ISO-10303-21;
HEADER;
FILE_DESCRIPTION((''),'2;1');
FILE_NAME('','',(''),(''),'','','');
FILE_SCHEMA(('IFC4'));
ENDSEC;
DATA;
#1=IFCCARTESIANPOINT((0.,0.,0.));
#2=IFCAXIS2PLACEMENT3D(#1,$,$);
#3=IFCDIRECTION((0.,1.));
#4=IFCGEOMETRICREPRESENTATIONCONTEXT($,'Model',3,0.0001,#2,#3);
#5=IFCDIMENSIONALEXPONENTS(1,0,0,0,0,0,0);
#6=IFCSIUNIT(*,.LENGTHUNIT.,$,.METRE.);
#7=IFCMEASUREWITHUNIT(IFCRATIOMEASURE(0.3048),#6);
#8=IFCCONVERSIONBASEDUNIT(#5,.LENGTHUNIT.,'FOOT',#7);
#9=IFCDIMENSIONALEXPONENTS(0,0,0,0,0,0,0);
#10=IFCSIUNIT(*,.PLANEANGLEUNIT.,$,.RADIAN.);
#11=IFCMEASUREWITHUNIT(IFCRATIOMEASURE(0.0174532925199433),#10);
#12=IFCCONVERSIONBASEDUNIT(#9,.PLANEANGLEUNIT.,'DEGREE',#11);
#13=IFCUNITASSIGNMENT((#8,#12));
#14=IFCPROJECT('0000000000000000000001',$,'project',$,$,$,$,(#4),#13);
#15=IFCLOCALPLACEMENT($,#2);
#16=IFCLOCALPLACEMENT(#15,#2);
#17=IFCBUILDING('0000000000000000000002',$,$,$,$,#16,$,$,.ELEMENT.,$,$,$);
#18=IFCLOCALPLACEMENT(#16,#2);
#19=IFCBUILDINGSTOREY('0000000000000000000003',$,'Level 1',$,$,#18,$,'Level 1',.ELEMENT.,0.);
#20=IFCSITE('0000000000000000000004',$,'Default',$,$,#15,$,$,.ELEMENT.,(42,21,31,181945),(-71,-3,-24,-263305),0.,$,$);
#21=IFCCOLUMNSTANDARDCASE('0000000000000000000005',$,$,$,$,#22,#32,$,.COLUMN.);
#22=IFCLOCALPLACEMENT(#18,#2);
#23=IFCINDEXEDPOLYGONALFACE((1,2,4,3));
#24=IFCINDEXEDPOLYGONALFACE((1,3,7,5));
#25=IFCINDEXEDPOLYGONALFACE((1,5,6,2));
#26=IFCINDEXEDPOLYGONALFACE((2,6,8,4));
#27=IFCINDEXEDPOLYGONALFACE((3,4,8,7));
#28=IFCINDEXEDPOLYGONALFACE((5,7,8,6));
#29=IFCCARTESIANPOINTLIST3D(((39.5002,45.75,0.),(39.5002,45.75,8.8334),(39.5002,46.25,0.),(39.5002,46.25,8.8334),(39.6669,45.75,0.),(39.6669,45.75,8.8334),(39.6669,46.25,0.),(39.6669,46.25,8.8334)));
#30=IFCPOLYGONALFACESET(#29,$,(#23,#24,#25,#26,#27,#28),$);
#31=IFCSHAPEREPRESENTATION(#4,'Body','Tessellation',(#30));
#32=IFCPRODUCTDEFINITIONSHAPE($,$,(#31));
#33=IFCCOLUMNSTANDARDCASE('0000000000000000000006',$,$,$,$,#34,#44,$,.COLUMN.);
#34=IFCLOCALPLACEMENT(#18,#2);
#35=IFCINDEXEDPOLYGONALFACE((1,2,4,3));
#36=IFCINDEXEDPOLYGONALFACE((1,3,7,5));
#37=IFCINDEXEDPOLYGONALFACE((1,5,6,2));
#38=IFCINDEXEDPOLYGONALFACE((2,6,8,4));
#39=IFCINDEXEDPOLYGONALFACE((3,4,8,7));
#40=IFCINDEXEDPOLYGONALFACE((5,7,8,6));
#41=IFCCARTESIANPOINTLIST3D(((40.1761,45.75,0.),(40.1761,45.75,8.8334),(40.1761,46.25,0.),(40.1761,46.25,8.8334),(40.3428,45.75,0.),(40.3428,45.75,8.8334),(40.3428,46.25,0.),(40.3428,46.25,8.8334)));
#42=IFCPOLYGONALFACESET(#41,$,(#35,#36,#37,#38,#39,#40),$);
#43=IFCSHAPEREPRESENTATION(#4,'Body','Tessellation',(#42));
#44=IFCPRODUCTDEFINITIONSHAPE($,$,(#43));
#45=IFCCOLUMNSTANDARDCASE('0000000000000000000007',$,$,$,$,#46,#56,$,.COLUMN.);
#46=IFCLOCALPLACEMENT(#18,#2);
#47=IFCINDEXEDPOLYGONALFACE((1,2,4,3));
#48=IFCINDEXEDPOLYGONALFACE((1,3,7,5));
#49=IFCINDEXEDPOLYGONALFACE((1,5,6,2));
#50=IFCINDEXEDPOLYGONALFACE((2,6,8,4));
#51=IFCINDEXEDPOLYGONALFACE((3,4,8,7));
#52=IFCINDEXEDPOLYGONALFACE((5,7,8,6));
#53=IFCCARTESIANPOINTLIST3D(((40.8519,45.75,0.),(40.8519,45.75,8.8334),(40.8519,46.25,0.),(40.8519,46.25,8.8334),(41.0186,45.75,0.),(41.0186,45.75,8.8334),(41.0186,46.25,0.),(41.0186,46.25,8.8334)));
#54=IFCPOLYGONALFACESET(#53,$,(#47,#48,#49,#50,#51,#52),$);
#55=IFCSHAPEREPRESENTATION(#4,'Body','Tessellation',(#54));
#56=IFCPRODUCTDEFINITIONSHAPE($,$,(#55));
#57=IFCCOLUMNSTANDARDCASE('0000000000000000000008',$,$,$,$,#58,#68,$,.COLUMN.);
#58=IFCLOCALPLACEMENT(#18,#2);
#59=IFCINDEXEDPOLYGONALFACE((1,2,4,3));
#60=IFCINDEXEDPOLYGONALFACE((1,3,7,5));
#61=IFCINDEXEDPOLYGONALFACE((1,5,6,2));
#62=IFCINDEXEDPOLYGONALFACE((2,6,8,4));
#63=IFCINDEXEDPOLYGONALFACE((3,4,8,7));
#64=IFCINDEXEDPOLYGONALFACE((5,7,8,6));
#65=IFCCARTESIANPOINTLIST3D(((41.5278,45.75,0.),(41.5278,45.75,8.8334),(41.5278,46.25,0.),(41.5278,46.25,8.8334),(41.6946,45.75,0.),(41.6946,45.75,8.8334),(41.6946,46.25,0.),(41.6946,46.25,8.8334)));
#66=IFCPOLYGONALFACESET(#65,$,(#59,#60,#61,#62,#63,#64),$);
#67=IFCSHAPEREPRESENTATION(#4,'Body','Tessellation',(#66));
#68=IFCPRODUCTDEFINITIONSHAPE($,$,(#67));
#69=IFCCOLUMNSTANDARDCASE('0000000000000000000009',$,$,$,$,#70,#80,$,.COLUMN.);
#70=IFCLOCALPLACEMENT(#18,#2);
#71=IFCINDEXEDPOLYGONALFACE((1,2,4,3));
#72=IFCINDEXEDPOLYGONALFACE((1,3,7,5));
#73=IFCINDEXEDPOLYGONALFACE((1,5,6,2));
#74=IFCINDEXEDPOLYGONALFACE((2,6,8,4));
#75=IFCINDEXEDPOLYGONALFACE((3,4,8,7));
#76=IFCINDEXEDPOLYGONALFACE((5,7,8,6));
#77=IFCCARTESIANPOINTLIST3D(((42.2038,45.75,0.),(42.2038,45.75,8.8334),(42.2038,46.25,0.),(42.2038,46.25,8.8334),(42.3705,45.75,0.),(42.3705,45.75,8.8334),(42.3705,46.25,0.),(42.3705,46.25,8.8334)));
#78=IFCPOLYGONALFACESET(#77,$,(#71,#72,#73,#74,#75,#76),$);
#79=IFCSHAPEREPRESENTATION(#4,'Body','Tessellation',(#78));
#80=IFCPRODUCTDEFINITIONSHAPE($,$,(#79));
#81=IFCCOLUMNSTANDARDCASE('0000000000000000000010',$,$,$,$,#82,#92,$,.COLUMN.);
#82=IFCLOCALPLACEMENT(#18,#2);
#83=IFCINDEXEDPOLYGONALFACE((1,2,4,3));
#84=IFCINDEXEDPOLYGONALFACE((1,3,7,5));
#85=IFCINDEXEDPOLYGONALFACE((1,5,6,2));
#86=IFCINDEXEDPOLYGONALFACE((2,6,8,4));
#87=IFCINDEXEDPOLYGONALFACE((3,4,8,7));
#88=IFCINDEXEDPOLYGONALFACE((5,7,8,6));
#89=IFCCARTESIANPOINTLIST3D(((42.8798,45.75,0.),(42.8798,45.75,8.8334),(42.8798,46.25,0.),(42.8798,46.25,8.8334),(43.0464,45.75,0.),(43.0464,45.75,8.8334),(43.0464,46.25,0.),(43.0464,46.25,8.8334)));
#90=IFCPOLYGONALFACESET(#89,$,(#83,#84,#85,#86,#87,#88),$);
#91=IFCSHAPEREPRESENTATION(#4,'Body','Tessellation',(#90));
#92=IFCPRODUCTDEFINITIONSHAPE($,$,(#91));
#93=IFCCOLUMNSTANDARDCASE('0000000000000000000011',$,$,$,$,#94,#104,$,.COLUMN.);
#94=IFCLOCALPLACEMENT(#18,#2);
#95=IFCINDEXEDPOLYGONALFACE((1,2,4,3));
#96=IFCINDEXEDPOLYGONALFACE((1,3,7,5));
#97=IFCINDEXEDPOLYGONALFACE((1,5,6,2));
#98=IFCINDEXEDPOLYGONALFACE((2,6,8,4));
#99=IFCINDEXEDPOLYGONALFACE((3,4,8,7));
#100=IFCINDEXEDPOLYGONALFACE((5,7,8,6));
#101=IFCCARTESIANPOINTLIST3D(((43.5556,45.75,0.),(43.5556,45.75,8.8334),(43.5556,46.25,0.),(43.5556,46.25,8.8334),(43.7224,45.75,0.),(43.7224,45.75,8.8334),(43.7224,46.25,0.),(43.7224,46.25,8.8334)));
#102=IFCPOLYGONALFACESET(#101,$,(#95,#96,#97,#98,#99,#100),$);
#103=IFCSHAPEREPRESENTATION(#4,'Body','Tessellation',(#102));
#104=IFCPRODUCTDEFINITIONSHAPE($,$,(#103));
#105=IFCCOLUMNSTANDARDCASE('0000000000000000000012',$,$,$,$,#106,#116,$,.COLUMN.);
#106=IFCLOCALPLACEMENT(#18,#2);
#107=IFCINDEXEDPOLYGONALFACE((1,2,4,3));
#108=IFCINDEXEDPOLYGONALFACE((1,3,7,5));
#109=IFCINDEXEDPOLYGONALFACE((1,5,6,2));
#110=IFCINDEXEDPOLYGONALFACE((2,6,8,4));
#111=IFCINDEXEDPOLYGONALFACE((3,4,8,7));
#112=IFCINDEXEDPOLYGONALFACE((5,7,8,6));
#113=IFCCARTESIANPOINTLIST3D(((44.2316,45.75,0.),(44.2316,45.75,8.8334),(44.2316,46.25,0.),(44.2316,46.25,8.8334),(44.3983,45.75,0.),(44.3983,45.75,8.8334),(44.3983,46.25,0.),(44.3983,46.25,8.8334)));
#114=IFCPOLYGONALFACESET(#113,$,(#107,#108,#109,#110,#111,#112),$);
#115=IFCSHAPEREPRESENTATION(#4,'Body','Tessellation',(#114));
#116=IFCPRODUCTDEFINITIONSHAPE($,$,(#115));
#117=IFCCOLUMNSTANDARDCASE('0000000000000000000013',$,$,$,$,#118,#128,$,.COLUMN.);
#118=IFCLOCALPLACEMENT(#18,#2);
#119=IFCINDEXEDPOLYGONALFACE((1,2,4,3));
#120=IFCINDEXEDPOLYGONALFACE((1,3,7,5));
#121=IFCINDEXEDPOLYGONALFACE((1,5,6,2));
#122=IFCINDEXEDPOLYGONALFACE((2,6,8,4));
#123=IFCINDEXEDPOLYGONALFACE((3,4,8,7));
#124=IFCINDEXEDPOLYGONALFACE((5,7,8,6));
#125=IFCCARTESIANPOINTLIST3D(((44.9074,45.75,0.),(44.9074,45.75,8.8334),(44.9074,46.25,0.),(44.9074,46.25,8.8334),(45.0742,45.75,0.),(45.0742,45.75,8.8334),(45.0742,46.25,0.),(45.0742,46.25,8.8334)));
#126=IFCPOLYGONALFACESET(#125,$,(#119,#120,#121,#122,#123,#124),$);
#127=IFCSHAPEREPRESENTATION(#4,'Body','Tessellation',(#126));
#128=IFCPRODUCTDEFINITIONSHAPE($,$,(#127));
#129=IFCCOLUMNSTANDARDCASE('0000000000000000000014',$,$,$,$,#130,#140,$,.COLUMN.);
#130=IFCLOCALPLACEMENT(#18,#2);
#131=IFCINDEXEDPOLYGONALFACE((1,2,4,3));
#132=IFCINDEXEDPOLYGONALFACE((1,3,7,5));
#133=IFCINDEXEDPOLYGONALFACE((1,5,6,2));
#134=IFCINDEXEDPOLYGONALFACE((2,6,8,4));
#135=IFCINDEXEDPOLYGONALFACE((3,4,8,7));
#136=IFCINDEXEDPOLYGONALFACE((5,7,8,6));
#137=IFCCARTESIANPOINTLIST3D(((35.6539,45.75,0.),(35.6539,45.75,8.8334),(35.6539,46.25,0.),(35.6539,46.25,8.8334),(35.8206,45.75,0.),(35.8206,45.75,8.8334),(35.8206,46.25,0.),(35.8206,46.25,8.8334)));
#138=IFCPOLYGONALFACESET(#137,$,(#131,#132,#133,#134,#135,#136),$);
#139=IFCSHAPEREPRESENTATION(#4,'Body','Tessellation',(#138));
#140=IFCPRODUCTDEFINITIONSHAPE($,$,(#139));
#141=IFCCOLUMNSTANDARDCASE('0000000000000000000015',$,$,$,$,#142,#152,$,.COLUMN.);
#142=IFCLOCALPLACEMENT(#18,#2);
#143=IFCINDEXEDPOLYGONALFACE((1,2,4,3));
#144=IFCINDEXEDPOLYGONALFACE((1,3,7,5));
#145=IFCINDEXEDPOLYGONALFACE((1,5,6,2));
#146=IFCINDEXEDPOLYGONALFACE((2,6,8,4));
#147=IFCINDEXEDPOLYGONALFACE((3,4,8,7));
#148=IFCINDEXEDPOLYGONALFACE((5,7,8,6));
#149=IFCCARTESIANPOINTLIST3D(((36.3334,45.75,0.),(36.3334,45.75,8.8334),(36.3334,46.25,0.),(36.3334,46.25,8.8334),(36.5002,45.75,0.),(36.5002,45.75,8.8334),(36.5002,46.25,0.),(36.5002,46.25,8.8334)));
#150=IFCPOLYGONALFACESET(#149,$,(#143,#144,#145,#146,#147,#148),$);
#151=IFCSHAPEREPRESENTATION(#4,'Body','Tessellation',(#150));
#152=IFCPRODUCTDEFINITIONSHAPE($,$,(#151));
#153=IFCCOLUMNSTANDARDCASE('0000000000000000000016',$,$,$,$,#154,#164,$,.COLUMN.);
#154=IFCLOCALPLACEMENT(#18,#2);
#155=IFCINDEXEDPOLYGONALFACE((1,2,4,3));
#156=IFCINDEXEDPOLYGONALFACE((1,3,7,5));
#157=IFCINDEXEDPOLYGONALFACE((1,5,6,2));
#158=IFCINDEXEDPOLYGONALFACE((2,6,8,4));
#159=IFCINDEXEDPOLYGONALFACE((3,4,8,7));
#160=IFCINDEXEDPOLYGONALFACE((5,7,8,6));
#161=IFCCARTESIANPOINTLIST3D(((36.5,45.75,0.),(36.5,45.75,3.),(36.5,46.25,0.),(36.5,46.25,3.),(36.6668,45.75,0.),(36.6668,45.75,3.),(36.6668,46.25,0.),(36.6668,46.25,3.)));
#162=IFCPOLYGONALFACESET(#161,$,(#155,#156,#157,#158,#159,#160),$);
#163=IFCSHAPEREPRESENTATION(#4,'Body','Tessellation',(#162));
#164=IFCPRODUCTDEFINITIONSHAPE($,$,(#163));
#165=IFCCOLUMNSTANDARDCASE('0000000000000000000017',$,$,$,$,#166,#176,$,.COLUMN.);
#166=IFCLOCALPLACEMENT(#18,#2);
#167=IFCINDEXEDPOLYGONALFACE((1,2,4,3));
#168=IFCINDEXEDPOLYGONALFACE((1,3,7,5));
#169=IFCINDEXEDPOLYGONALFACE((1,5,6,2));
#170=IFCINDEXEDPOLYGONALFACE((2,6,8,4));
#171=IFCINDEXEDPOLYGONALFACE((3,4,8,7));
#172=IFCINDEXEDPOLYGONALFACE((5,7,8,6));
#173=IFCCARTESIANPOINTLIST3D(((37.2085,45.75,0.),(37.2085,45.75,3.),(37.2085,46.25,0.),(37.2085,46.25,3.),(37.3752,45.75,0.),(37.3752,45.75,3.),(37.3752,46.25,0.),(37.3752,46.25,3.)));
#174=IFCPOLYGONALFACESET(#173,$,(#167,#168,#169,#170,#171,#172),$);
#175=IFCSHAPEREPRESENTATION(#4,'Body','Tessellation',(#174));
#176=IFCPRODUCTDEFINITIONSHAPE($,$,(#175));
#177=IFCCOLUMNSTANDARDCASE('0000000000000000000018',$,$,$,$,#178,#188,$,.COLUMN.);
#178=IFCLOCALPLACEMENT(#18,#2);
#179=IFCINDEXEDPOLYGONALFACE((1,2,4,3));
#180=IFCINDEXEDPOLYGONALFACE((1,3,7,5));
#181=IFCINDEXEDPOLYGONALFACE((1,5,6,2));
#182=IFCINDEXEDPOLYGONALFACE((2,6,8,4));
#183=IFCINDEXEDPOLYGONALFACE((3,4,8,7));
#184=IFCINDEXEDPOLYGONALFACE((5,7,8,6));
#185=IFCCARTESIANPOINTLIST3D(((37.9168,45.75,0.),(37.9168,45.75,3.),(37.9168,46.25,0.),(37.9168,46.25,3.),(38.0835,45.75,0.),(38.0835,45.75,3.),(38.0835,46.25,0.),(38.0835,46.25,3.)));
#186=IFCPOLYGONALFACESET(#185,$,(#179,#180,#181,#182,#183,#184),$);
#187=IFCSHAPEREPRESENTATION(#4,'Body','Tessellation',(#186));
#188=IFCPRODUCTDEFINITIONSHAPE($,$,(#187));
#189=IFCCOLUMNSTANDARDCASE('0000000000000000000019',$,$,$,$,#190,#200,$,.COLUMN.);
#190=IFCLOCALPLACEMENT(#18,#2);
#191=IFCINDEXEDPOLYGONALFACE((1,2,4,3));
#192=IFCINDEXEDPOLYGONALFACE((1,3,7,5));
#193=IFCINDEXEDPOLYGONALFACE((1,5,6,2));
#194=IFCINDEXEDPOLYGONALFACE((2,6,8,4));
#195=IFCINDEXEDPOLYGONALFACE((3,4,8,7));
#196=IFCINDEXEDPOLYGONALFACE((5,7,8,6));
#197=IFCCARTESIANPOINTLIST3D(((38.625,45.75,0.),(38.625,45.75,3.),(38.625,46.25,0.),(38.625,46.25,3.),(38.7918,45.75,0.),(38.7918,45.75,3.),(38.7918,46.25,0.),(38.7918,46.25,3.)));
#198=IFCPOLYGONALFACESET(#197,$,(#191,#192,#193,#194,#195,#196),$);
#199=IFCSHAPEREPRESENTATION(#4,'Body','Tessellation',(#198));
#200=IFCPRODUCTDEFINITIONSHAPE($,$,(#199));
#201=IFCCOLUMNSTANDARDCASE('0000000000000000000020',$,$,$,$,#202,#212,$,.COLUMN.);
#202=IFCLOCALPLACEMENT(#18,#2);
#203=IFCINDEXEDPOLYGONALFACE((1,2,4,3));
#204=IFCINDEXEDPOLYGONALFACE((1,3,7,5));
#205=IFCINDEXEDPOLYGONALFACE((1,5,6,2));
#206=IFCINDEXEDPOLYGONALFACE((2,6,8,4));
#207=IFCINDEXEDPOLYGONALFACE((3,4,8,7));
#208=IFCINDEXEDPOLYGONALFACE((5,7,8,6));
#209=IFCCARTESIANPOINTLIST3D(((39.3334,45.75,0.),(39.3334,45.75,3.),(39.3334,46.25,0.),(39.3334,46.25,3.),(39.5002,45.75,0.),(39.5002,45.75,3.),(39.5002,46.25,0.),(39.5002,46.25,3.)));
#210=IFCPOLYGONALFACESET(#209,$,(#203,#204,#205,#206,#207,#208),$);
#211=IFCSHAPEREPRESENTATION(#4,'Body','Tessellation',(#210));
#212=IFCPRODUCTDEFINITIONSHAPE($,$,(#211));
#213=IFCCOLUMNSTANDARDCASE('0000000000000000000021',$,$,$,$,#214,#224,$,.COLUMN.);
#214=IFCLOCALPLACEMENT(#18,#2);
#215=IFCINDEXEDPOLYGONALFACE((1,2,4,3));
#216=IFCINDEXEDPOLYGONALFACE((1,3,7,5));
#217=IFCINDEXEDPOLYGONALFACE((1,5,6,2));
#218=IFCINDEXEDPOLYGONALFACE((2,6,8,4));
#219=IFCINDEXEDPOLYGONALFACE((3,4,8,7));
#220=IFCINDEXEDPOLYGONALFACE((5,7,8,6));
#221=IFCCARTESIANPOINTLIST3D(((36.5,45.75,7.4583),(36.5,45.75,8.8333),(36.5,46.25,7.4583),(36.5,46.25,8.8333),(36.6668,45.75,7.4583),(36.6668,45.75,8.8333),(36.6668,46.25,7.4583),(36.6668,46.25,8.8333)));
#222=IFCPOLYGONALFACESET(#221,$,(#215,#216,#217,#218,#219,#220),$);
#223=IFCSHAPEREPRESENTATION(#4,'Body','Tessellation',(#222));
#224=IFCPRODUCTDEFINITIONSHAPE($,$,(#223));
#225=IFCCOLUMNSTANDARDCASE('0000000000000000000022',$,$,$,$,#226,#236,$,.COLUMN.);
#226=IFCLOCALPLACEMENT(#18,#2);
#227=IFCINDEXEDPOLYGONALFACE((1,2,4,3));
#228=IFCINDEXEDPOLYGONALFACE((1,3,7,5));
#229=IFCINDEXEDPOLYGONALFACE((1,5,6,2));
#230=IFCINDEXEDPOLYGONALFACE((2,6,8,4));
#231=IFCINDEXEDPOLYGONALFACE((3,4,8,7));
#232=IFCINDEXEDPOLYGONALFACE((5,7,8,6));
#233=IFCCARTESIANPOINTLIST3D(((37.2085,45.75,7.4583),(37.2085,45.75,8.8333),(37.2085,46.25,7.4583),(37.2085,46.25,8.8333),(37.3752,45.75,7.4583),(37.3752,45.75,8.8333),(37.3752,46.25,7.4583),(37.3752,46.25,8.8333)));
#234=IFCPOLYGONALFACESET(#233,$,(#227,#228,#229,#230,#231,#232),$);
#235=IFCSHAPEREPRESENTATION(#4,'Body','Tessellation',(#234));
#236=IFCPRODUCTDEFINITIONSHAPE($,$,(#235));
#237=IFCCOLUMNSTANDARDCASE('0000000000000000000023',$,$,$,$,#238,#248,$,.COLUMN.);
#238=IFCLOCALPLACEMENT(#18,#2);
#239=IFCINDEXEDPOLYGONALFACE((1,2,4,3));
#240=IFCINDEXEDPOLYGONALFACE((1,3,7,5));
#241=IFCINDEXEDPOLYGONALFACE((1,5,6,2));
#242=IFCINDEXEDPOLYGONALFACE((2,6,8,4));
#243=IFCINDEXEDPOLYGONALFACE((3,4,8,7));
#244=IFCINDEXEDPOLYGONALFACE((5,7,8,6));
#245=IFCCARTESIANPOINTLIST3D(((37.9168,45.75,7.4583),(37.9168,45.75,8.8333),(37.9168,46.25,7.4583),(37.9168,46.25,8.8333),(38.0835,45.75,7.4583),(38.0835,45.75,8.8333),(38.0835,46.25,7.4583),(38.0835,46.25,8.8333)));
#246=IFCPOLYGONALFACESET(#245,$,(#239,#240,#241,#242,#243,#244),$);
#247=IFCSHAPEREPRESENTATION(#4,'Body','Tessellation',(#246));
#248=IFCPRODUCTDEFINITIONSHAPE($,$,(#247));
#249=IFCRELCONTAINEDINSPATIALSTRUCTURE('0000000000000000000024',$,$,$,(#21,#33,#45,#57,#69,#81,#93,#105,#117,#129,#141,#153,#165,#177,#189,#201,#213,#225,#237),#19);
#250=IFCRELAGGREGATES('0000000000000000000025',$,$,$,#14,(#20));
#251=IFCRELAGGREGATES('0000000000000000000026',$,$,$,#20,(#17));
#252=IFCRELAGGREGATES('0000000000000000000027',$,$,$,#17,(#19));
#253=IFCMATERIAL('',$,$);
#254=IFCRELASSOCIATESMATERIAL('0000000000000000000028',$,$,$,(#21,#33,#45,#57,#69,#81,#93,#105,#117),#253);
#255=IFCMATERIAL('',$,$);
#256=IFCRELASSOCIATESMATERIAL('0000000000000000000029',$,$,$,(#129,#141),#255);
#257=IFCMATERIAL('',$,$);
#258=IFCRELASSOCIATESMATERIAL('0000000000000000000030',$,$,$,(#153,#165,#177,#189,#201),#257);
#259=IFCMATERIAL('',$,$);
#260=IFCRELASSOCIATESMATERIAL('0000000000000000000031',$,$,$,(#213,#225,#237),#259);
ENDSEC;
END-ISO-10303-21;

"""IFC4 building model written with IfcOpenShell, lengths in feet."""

from ifc_helpers import new_model, entity, si_unit, converted_unit, direction, frame, origin, place, context, project, spatial, rectangle, extrude, material, element, save


model = new_model("IFC4")

# Units and contexts
model_context = context("Model", 3, precision=0.0001, world=origin(), true_north=direction((0.0, 1.0)))
ifc_project = project(units=[converted_unit("LENGTHUNIT", "FOOT", entity("IfcRatioMeasure", 0.3048), si_unit("LENGTHUNIT", "METRE"), dimensions=[1, 0, 0, 0, 0, 0, 0]), converted_unit("PLANEANGLEUNIT", "DEGREE", entity("IfcRatioMeasure", 0.0174532925199433), si_unit("PLANEANGLEUNIT", "RADIAN"), dimensions=[0, 0, 0, 0, 0, 0, 0])], contexts=[model_context])

# Site, building, storey
site_placement = place(None, origin())
site = spatial("IfcSite", under=ifc_project, at=site_placement, Name="Default", CompositionType="ELEMENT", RefLatitude=(42, 21, 31, 181945), RefLongitude=(-71, -3, -24, -263305), RefElevation=0.0)
building_placement = place(site_placement, origin())
building = spatial("IfcBuilding", under=site, at=building_placement, CompositionType="ELEMENT")
storey_placement = place(building_placement, origin())
storey = spatial("IfcBuildingStorey", under=building, at=storey_placement, Name="Level 1", LongName="Level 1", CompositionType="ELEMENT", Elevation=0.0)

# Columns
ifc_material_1 = material(Name="")
placement_1 = place(storey_placement, frame((-0.25, 46.0, 0.0)))
for number, where, z_axis, x_axis in (
    (1, (39.8335, 0.0, 0.0), (0.0, 0.0, 1.0), (1.0, 0.0, 0.0)),
    (2, (40.5094, 0.0, 0.0), (0.0, 0.0, 1.0), (1.0, 0.0, 0.0)),
    (3, (41.1853, 0.0, 0.0), (0.0, 0.0, 1.0), (1.0, 0.0, 0.0)),
    (4, (41.8612, 0.0, 0.0), (0.0, 0.0, 1.0), (1.0, 0.0, 0.0)),
    (5, (42.5371, 0.0, 0.0), (0.0, 0.0, 1.0), (1.0, 0.0, 0.0)),
    (6, (43.2131, 0.0, 0.0), (0.0, 0.0, 1.0), (1.0, 0.0, 0.0)),
    (7, (43.889, 0.0, 0.0), (0.0, 0.0, 1.0), (1.0, 0.0, 0.0)),
    (8, (44.5649, 0.0, 0.0), (0.0, 0.0, 1.0), (1.0, 0.0, 0.0)),
    (9, (45.2408, 0.0, 0.0), (0.0, 0.0, 1.0), (1.0, 0.0, 0.0)),
):
    element("IfcColumnStandardCase", number, at=place(placement_1, frame(where, z_axis=z_axis, x_axis=x_axis)), inside=storey, material=ifc_material_1, PredefinedType="COLUMN", context=model_context, shape_type="SweptSolid", body=[
        extrude(rectangle(XDim=0.1667, YDim=0.5), origin(), (0.0, 0.0, 1.0), 8.8334),
    ])
ifc_material_2 = material(Name="")
for number, where, z_axis, x_axis in (
    (10, (35.9873, 0.0, 0.0), (0.0, 0.0, 1.0), (1.0, 0.0, 0.0)),
    (11, (36.6668, 0.0, 0.0), (0.0, 0.0, 1.0), (1.0, 0.0, 0.0)),
):
    element("IfcColumnStandardCase", number, at=place(placement_1, frame(where, z_axis=z_axis, x_axis=x_axis)), inside=storey, material=ifc_material_2, PredefinedType="COLUMN", context=model_context, shape_type="SweptSolid", body=[
        extrude(rectangle(XDim=0.1667, YDim=0.5), origin(), (0.0, 0.0, 1.0), 8.8334),
    ])
ifc_material_3 = material(Name="")
for number, where, z_axis, x_axis in (
    (12, (36.8334, 0.0, 0.0), (0.0, 0.0, 1.0), (1.0, 0.0, 0.0)),
    (13, (37.5418, 0.0, 0.0), (0.0, 0.0, 1.0), (1.0, 0.0, 0.0)),
    (14, (38.2501, 0.0, 0.0), (0.0, 0.0, 1.0), (1.0, 0.0, 0.0)),
    (15, (38.9584, 0.0, 0.0), (0.0, 0.0, 1.0), (1.0, 0.0, 0.0)),
    (16, (39.6668, 0.0, 0.0), (0.0, 0.0, 1.0), (1.0, 0.0, 0.0)),
):
    element("IfcColumnStandardCase", number, at=place(placement_1, frame(where, z_axis=z_axis, x_axis=x_axis)), inside=storey, material=ifc_material_3, PredefinedType="COLUMN", context=model_context, shape_type="SweptSolid", body=[
        extrude(rectangle(XDim=0.1667, YDim=0.5), origin(), (0.0, 0.0, 1.0), 3.0),
    ])
ifc_material_4 = material(Name="")
for number, where, z_axis, x_axis in (
    (17, (36.8334, 0.0, 7.4583), (0.0, 0.0, 1.0), (1.0, 0.0, 0.0)),
    (18, (37.5418, 0.0, 7.4583), (0.0, 0.0, 1.0), (1.0, 0.0, 0.0)),
    (19, (38.2501, 0.0, 7.4583), (0.0, 0.0, 1.0), (1.0, 0.0, 0.0)),
):
    element("IfcColumnStandardCase", number, at=place(placement_1, frame(where, z_axis=z_axis, x_axis=x_axis)), inside=storey, material=ifc_material_4, PredefinedType="COLUMN", context=model_context, shape_type="SweptSolid", body=[
        extrude(rectangle(XDim=0.1667, YDim=0.5), origin(), (0.0, 0.0, 1.0), 1.375),
    ])

save(model, "model.ifc")
